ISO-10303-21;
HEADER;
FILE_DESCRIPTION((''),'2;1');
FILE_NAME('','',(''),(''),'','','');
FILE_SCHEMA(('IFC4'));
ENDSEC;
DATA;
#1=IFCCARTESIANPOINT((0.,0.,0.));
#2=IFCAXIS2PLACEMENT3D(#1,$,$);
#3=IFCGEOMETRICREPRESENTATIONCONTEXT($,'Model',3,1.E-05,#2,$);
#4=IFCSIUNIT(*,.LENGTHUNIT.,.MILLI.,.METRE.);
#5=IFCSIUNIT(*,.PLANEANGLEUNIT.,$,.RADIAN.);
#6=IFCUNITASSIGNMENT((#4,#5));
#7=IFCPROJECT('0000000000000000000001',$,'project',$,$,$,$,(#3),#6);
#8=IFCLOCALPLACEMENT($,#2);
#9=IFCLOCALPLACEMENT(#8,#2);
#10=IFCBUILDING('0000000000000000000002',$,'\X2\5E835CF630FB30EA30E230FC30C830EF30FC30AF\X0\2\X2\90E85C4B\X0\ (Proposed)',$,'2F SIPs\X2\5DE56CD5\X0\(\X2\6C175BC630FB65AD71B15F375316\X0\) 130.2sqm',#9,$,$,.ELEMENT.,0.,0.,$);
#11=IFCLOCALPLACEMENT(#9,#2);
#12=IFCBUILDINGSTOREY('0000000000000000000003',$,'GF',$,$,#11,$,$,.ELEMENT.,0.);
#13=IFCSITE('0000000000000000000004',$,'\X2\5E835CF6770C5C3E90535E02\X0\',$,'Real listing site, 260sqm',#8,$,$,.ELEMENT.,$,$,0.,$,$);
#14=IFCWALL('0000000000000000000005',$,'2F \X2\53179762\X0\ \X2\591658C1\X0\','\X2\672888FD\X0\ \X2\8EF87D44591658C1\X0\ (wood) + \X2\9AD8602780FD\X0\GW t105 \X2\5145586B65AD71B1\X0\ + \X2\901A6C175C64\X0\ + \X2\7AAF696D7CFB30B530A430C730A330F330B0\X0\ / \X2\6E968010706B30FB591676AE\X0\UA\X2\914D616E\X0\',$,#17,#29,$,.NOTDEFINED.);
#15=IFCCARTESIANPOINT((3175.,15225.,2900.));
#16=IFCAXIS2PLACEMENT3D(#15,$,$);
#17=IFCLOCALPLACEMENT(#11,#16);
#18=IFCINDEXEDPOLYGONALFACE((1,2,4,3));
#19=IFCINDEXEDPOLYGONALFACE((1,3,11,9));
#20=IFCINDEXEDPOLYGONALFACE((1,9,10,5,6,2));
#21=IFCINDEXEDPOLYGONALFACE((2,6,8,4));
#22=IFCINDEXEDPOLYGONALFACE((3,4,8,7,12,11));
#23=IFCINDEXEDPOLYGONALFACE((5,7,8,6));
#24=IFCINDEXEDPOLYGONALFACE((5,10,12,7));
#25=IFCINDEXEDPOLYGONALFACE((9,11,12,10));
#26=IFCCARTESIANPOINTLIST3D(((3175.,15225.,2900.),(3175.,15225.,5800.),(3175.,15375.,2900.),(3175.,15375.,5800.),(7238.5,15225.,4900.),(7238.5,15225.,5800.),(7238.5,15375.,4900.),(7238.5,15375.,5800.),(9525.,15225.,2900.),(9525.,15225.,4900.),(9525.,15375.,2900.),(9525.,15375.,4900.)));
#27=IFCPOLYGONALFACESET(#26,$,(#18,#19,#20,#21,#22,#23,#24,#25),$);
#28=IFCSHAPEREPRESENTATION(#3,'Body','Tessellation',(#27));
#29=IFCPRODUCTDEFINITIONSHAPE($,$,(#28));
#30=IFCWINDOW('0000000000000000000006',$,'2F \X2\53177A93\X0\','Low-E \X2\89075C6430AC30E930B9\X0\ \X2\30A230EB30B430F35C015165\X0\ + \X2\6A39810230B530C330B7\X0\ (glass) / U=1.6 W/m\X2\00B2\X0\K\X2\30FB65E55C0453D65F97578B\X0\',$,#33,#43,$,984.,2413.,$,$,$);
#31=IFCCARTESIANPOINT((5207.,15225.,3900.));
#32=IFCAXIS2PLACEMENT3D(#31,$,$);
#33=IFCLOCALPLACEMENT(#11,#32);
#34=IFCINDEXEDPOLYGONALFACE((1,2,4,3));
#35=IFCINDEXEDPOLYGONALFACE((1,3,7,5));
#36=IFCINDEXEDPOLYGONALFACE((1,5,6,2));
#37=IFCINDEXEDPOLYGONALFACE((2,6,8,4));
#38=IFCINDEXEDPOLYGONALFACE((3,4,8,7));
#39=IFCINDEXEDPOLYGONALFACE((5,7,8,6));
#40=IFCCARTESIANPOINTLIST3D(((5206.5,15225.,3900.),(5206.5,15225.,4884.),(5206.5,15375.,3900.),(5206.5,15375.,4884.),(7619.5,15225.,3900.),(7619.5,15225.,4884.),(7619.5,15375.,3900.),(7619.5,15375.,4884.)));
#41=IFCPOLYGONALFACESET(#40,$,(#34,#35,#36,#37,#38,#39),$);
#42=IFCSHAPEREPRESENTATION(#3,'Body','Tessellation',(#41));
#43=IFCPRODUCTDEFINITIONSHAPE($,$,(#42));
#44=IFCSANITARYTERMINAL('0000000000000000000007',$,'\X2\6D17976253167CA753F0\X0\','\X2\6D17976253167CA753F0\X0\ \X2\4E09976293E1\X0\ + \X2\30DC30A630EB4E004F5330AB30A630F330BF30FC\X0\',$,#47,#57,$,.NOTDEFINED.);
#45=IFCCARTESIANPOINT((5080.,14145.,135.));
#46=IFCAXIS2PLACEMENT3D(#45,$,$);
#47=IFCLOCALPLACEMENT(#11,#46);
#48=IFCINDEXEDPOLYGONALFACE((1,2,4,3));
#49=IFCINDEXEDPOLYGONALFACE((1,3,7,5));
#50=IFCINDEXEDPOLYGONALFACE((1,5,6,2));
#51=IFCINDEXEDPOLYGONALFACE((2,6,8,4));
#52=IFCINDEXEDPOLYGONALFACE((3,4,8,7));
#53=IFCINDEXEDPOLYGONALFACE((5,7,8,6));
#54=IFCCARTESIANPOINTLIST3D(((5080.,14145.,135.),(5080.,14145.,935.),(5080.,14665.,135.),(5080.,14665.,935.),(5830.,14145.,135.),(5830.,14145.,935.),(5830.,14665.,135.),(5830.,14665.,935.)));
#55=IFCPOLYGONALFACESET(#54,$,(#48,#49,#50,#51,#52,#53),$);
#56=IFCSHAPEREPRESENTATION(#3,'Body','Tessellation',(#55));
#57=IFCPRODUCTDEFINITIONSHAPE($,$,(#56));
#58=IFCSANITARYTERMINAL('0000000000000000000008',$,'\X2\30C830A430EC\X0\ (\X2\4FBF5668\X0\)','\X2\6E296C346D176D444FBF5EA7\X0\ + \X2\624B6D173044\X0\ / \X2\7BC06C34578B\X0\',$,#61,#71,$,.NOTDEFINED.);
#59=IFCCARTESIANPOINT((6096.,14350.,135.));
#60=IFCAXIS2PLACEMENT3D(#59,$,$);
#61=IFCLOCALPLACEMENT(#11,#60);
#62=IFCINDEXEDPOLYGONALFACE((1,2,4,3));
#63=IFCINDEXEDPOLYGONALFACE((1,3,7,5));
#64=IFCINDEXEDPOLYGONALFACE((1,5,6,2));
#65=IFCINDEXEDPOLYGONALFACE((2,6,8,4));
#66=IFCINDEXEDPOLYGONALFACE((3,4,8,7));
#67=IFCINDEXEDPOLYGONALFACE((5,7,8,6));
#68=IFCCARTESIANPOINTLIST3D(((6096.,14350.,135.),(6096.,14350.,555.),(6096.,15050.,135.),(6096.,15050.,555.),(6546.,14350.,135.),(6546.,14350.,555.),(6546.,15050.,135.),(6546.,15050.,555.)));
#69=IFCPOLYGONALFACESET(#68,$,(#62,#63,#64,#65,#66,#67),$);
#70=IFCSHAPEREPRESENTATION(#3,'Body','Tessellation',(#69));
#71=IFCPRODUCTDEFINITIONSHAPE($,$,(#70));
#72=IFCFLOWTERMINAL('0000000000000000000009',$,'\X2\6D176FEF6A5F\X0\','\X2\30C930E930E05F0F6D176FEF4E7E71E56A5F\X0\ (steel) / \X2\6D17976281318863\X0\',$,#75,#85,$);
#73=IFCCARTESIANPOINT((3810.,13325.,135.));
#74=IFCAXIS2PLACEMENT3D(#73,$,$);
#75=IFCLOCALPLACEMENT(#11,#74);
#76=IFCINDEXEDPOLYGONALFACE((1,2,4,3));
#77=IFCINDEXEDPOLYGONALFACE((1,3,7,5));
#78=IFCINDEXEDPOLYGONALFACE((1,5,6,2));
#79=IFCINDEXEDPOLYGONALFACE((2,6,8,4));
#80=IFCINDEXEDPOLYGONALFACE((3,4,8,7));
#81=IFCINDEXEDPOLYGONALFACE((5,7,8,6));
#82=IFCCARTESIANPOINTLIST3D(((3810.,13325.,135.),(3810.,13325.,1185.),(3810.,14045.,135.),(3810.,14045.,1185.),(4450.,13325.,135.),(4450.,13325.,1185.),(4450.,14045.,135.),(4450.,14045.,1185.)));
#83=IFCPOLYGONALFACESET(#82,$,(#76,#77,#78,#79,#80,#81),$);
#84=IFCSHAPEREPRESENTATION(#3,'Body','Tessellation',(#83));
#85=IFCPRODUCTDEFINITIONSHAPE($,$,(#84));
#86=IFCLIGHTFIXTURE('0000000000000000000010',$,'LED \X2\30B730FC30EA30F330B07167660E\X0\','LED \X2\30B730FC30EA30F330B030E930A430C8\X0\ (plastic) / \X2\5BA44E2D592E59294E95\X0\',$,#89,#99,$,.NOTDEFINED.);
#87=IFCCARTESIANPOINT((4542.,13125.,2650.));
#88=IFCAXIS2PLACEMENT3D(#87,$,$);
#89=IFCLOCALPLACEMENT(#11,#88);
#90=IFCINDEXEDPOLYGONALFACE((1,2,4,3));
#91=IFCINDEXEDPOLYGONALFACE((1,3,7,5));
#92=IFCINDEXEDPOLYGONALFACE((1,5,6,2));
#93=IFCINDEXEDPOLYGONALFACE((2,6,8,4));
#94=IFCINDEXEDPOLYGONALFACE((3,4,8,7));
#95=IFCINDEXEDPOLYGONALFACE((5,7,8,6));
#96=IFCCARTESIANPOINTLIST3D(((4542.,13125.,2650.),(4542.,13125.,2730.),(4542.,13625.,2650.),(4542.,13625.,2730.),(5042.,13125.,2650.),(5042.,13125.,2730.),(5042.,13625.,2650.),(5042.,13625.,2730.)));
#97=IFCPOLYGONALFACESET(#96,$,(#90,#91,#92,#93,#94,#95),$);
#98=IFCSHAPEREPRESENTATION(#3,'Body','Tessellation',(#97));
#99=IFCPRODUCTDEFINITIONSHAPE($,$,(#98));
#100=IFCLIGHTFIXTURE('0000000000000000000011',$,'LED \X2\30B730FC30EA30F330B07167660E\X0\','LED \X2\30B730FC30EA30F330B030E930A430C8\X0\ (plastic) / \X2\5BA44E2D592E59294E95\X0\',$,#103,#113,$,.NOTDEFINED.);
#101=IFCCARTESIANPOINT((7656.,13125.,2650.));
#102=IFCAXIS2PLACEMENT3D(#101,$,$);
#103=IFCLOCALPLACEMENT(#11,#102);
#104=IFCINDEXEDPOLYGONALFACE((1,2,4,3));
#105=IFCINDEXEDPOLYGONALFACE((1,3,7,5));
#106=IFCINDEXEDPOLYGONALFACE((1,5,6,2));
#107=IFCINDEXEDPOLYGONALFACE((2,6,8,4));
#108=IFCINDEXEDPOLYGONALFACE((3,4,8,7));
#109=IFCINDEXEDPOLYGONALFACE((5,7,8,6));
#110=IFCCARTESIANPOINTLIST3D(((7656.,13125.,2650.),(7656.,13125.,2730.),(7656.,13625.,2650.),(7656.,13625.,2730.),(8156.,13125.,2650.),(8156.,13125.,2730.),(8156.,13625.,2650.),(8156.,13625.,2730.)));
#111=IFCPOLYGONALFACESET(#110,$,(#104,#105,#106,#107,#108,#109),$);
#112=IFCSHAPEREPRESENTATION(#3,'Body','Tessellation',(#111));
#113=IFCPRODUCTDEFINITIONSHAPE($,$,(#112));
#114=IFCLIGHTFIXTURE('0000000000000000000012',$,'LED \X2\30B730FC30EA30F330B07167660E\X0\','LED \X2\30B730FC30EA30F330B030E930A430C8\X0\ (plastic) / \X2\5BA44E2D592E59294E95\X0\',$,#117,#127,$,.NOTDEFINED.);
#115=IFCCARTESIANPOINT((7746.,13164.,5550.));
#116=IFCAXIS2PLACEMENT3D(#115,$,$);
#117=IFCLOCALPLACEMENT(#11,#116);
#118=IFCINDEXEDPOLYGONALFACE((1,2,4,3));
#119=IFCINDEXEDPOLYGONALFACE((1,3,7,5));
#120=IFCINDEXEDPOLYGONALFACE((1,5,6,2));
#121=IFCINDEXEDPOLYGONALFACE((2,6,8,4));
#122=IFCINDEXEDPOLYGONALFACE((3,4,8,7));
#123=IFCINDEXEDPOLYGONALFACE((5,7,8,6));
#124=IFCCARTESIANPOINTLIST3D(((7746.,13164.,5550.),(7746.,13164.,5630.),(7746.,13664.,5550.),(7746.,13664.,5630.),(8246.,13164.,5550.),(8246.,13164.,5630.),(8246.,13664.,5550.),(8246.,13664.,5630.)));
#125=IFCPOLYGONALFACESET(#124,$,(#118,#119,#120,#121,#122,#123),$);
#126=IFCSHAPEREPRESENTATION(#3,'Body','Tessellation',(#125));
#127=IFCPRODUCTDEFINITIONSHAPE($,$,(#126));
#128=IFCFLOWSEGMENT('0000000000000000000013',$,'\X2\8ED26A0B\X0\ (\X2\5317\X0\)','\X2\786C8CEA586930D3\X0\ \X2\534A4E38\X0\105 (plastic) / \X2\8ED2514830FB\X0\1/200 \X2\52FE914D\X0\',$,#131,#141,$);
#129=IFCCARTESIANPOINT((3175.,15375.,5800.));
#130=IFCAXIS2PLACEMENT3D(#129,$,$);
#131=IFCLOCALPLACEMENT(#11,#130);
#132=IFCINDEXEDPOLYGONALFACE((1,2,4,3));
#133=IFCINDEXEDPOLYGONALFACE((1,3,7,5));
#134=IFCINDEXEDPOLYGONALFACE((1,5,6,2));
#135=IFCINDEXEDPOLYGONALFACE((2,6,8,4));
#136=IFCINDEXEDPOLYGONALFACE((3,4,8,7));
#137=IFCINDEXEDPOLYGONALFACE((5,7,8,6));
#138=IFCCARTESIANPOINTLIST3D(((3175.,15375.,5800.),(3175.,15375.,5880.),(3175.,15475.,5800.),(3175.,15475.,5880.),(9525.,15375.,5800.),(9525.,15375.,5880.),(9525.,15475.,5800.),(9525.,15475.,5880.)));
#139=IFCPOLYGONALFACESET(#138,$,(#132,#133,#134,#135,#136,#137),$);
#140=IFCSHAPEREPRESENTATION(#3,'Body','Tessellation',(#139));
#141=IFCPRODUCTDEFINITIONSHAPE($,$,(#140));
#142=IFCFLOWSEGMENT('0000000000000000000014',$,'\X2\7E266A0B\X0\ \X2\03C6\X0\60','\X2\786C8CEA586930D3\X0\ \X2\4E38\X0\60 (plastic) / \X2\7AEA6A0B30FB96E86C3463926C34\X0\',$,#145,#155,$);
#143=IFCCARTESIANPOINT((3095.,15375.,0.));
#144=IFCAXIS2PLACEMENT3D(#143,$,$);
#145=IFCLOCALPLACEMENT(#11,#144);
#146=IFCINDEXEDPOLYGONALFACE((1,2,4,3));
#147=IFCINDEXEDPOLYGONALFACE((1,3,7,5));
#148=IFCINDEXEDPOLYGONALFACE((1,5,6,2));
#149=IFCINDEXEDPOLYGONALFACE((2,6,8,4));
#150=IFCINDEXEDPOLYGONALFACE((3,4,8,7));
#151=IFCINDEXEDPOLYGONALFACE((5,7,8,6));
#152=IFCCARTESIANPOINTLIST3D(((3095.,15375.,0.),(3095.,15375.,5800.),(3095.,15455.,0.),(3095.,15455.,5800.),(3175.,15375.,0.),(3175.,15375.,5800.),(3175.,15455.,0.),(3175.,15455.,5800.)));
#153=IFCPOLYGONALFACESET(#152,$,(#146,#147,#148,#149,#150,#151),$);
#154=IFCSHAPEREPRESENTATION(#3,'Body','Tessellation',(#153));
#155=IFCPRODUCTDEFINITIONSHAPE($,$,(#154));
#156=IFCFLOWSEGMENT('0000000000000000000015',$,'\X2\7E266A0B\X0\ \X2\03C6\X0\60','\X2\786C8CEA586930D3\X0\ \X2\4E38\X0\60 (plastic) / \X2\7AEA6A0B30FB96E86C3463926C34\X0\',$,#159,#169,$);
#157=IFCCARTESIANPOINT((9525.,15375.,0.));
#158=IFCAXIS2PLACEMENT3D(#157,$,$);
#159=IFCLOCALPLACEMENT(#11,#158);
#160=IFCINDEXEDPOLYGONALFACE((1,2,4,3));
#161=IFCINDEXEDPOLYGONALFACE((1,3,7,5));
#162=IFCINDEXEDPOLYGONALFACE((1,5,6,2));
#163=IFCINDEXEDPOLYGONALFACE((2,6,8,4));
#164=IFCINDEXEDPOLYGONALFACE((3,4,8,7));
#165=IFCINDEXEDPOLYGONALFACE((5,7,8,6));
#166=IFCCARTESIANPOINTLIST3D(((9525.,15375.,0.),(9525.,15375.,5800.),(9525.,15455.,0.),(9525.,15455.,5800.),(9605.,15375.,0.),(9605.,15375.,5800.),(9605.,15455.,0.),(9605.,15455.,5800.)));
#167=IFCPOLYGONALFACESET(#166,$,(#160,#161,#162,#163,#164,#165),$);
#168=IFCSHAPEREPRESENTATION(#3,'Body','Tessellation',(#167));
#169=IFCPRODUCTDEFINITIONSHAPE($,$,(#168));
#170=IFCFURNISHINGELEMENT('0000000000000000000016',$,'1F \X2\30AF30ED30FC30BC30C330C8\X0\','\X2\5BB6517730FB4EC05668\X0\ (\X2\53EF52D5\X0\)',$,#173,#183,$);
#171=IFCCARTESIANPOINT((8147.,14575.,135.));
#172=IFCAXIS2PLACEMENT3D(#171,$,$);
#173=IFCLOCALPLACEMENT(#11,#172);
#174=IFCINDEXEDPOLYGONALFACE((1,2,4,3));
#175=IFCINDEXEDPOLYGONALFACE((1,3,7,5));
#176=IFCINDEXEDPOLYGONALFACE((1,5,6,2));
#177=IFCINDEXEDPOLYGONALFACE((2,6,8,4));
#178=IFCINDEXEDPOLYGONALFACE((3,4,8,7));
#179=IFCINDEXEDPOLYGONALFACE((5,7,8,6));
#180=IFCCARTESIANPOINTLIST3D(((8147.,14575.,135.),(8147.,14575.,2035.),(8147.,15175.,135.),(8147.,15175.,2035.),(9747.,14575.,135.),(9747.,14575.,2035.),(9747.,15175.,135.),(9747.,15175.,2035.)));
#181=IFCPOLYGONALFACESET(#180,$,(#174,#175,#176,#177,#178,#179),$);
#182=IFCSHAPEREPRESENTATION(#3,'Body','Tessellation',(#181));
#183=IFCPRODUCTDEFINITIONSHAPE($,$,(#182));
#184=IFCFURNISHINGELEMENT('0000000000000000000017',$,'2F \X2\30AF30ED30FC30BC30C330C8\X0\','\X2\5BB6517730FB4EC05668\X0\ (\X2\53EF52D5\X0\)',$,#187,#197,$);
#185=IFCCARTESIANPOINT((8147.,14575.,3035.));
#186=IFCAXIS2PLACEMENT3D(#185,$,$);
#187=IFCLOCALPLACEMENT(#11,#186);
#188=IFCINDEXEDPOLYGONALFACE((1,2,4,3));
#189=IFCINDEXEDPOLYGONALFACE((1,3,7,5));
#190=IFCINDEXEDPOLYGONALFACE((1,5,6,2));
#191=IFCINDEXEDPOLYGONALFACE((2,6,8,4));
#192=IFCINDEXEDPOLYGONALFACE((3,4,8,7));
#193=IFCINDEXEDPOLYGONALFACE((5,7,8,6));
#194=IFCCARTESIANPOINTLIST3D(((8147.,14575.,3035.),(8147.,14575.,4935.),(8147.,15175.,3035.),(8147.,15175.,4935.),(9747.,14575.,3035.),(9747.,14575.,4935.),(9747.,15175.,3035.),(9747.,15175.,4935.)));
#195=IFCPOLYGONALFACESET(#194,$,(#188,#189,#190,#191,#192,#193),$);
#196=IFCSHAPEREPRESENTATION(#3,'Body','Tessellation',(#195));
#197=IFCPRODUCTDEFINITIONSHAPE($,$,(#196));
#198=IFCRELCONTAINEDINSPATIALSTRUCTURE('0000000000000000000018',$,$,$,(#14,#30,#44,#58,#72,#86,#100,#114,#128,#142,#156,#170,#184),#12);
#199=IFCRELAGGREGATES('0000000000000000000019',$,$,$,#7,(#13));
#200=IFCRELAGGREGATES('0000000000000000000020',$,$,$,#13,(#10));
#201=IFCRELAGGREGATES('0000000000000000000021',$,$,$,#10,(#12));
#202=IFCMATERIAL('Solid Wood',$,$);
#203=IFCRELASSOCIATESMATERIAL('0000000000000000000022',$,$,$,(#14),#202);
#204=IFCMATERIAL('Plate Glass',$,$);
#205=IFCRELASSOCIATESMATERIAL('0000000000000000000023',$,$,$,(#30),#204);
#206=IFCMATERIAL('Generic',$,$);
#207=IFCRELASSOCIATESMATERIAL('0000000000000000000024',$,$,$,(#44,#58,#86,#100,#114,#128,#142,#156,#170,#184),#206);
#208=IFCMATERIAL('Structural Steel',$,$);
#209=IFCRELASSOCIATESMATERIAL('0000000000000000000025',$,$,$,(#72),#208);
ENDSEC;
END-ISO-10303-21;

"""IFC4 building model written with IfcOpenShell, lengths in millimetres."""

from ifc_helpers import new_model, si_unit, frame, frame_2d, origin, place, context, project, spatial, rectangle, extrude, material, element, fill, save


model = new_model("IFC4")

# Units and contexts
model_context = context("Model", 3, precision=1e-05, world=origin())
ifc_project = project(units=[si_unit("LENGTHUNIT", "METRE", prefix="MILLI"), si_unit("PLANEANGLEUNIT", "RADIAN")], contexts=[model_context])

# Site, building, storey
site_placement = place(None, origin())
site = spatial("IfcSite", under=ifc_project, at=site_placement, Name="広島県尾道市", ObjectType="Real listing site, 260sqm", CompositionType="ELEMENT", RefElevation=0.0)
building_placement = place(site_placement, origin())
building = spatial("IfcBuilding", under=site, at=building_placement, Name="広島・リモートワーク2部屋 (Proposed)", ObjectType="2F SIPs工法(気密・断熱強化) 130.2sqm", CompositionType="ELEMENT", ElevationOfRefHeight=0.0, ElevationOfTerrain=0.0)
storey_placement = place(building_placement, origin())
storey = spatial("IfcBuildingStorey", under=building, at=storey_placement, Name="GF", CompositionType="ELEMENT", Elevation=0.0)

# Shared definitions
ifc_material_1 = material(Name="Solid Wood")

# Shared definitions
ifc_material_2 = material(Name="Plate Glass")

# Wall, opening, window
wall_1_placement = place(storey_placement, frame((3175.0, 15225.0, 2900.0)))
wall_1 = element("IfcWall", 1, at=wall_1_placement, inside=storey, material=ifc_material_1, Name="2F 北面 外壁", Description="木製 軸組外壁 (wood) + 高性能GW t105 充填断熱 + 通気層 + 窯業系サイディング / 準耐火・外皮UA配慮", PredefinedType="NOTDEFINED", context=model_context, shape_type="SweptSolid", body=[
    extrude(rectangle(XDim=6350.0, YDim=150.0, at=frame_2d((3175.0, 75.0))), frame((3175.0, 15225.0, 2900.0)), (0.0, 0.0, 1.0), 2900.0),
])
opening_1_placement = place(storey_placement, frame((5207.0, 15225.0, 3900.0)))
opening_1 = element("IfcOpeningElement", 2, at=opening_1_placement, cuts=wall_1, PredefinedType="NOTDEFINED", context=model_context, shape_type="SweptSolid", body=[
    extrude(rectangle(XDim=2413.0, YDim=150.0, at=frame_2d((1206.0, 75.0))), frame((5207.0, 15225.0, 3900.0)), (0.0, 0.0, 1.0), 984.0),
])
window_1_placement = place(storey_placement, frame((5207.0, 15225.0, 3900.0)))
window_1 = element("IfcWindow", 3, at=window_1_placement, inside=storey, material=ifc_material_2, Name="2F 北窓", Description="Low-E 複層ガラス アルゴン封入 + 樹脂サッシ (glass) / U=1.6 W/m²K・日射取得型", OverallHeight=984.0, OverallWidth=2413.0, context=model_context, shape_type="SweptSolid", body=[
    extrude(rectangle(XDim=2413.0, YDim=150.0, at=frame_2d((1206.0, 75.0))), frame((5207.0, 15225.0, 3900.0)), (0.0, 0.0, 1.0), 984.0),
])
fill(opening_1, window_1)

# Sanitary terminals
ifc_material_3 = material(Name="Generic")
sanitary_terminal_1_placement = place(storey_placement, frame((5080.0, 14145.0, 135.0)))
element("IfcSanitaryTerminal", 4, at=sanitary_terminal_1_placement, inside=storey, material=ifc_material_3, Name="洗面化粧台", Description="洗面化粧台 三面鏡 + ボウル一体カウンター", PredefinedType="NOTDEFINED", context=model_context, shape_type="SweptSolid", body=[
    extrude(rectangle(XDim=750.0, YDim=520.0, at=frame_2d((375.0, 260.0))), frame((5080.0, 14145.0, 135.0)), (0.0, 0.0, 1.0), 800.0),
])
sanitary_terminal_2_placement = place(storey_placement, frame((6096.0, 14350.0, 135.0)))
element("IfcSanitaryTerminal", 5, at=sanitary_terminal_2_placement, inside=storey, material=ifc_material_3, Name="トイレ (便器)", Description="温水洗浄便座 + 手洗い / 節水型", PredefinedType="NOTDEFINED", context=model_context, shape_type="SweptSolid", body=[
    extrude(rectangle(XDim=450.0, YDim=700.0, at=frame_2d((225.0, 350.0))), frame((6096.0, 14350.0, 135.0)), (0.0, 0.0, 1.0), 420.0),
])

# Flow terminal
ifc_material_4 = material(Name="Structural Steel")
flow_terminal_placement = place(storey_placement, frame((3810.0, 13325.0, 135.0)))
element("IfcFlowTerminal", 6, at=flow_terminal_placement, inside=storey, material=ifc_material_4, Name="洗濯機", Description="ドラム式洗濯乾燥機 (steel) / 洗面脱衣", context=model_context, shape_type="SweptSolid", body=[
    extrude(rectangle(XDim=640.0, YDim=720.0, at=frame_2d((320.0, 360.0))), frame((3810.0, 13325.0, 135.0)), (0.0, 0.0, 1.0), 1050.0),
])

# Light fixtures
light_fixture_1_placement = place(storey_placement, frame((4542.0, 13125.0, 2650.0)))
element("IfcLightFixture", 7, at=light_fixture_1_placement, inside=storey, material=ifc_material_3, Name="LED シーリング照明", Description="LED シーリングライト (plastic) / 室中央天井", PredefinedType="NOTDEFINED", context=model_context, shape_type="SweptSolid", body=[
    extrude(rectangle(XDim=500.0, YDim=500.0, at=frame_2d((250.0, 250.0))), frame((4542.0, 13125.0, 2650.0)), (0.0, 0.0, 1.0), 80.0),
])
light_fixture_2_placement = place(storey_placement, frame((7656.0, 13125.0, 2650.0)))
element("IfcLightFixture", 8, at=light_fixture_2_placement, inside=storey, material=ifc_material_3, Name="LED シーリング照明", Description="LED シーリングライト (plastic) / 室中央天井", PredefinedType="NOTDEFINED", context=model_context, shape_type="SweptSolid", body=[
    extrude(rectangle(XDim=500.0, YDim=500.0, at=frame_2d((250.0, 250.0))), frame((7656.0, 13125.0, 2650.0)), (0.0, 0.0, 1.0), 80.0),
])
light_fixture_3_placement = place(storey_placement, frame((7746.0, 13164.0, 5550.0)))
element("IfcLightFixture", 9, at=light_fixture_3_placement, inside=storey, material=ifc_material_3, Name="LED シーリング照明", Description="LED シーリングライト (plastic) / 室中央天井", PredefinedType="NOTDEFINED", context=model_context, shape_type="SweptSolid", body=[
    extrude(rectangle(XDim=500.0, YDim=500.0, at=frame_2d((250.0, 250.0))), frame((7746.0, 13164.0, 5550.0)), (0.0, 0.0, 1.0), 80.0),
])

# Flow segments
flow_segment_1_placement = place(storey_placement, frame((3175.0, 15375.0, 5800.0)))
element("IfcFlowSegment", 10, at=flow_segment_1_placement, inside=storey, material=ifc_material_3, Name="軒樋 (北)", Description="硬質塩ビ 半丸105 (plastic) / 軒先・1/200 勾配", context=model_context, shape_type="SweptSolid", body=[
    extrude(rectangle(XDim=6350.0, YDim=100.0, at=frame_2d((3175.0, 50.0))), frame((3175.0, 15375.0, 5800.0)), (0.0, 0.0, 1.0), 80.0),
])
flow_segment_2_placement = place(storey_placement, frame((3095.0, 15375.0, 0.0)))
element("IfcFlowSegment", 11, at=flow_segment_2_placement, inside=storey, material=ifc_material_3, Name="縦樋 φ60", Description="硬質塩ビ 丸60 (plastic) / 竪樋・雨水排水", context=model_context, shape_type="SweptSolid", body=[
    extrude(rectangle(XDim=80.0, YDim=80.0, at=frame_2d((40.0, 40.0))), frame((3095.0, 15375.0, 0.0)), (0.0, 0.0, 1.0), 5800.0),
])
flow_segment_3_placement = place(storey_placement, frame((9525.0, 15375.0, 0.0)))
element("IfcFlowSegment", 12, at=flow_segment_3_placement, inside=storey, material=ifc_material_3, Name="縦樋 φ60", Description="硬質塩ビ 丸60 (plastic) / 竪樋・雨水排水", context=model_context, shape_type="SweptSolid", body=[
    extrude(rectangle(XDim=80.0, YDim=80.0, at=frame_2d((40.0, 40.0))), frame((9525.0, 15375.0, 0.0)), (0.0, 0.0, 1.0), 5800.0),
])

# Furnishing elements
furnishing_1_placement = place(storey_placement, frame((8147.0, 14575.0, 135.0)))
element("IfcFurnishingElement", 13, at=furnishing_1_placement, inside=storey, material=ifc_material_3, Name="1F クローゼット", Description="家具・什器 (可動)", context=model_context, shape_type="SweptSolid", body=[
    extrude(rectangle(XDim=1600.0, YDim=600.0, at=frame_2d((800.0, 300.0))), frame((8147.0, 14575.0, 135.0)), (0.0, 0.0, 1.0), 1900.0),
])
furnishing_2_placement = place(storey_placement, frame((8147.0, 14575.0, 3035.0)))
element("IfcFurnishingElement", 14, at=furnishing_2_placement, inside=storey, material=ifc_material_3, Name="2F クローゼット", Description="家具・什器 (可動)", context=model_context, shape_type="SweptSolid", body=[
    extrude(rectangle(XDim=1600.0, YDim=600.0, at=frame_2d((800.0, 300.0))), frame((8147.0, 14575.0, 3035.0)), (0.0, 0.0, 1.0), 1900.0),
])

save(model, "model.ifc")
